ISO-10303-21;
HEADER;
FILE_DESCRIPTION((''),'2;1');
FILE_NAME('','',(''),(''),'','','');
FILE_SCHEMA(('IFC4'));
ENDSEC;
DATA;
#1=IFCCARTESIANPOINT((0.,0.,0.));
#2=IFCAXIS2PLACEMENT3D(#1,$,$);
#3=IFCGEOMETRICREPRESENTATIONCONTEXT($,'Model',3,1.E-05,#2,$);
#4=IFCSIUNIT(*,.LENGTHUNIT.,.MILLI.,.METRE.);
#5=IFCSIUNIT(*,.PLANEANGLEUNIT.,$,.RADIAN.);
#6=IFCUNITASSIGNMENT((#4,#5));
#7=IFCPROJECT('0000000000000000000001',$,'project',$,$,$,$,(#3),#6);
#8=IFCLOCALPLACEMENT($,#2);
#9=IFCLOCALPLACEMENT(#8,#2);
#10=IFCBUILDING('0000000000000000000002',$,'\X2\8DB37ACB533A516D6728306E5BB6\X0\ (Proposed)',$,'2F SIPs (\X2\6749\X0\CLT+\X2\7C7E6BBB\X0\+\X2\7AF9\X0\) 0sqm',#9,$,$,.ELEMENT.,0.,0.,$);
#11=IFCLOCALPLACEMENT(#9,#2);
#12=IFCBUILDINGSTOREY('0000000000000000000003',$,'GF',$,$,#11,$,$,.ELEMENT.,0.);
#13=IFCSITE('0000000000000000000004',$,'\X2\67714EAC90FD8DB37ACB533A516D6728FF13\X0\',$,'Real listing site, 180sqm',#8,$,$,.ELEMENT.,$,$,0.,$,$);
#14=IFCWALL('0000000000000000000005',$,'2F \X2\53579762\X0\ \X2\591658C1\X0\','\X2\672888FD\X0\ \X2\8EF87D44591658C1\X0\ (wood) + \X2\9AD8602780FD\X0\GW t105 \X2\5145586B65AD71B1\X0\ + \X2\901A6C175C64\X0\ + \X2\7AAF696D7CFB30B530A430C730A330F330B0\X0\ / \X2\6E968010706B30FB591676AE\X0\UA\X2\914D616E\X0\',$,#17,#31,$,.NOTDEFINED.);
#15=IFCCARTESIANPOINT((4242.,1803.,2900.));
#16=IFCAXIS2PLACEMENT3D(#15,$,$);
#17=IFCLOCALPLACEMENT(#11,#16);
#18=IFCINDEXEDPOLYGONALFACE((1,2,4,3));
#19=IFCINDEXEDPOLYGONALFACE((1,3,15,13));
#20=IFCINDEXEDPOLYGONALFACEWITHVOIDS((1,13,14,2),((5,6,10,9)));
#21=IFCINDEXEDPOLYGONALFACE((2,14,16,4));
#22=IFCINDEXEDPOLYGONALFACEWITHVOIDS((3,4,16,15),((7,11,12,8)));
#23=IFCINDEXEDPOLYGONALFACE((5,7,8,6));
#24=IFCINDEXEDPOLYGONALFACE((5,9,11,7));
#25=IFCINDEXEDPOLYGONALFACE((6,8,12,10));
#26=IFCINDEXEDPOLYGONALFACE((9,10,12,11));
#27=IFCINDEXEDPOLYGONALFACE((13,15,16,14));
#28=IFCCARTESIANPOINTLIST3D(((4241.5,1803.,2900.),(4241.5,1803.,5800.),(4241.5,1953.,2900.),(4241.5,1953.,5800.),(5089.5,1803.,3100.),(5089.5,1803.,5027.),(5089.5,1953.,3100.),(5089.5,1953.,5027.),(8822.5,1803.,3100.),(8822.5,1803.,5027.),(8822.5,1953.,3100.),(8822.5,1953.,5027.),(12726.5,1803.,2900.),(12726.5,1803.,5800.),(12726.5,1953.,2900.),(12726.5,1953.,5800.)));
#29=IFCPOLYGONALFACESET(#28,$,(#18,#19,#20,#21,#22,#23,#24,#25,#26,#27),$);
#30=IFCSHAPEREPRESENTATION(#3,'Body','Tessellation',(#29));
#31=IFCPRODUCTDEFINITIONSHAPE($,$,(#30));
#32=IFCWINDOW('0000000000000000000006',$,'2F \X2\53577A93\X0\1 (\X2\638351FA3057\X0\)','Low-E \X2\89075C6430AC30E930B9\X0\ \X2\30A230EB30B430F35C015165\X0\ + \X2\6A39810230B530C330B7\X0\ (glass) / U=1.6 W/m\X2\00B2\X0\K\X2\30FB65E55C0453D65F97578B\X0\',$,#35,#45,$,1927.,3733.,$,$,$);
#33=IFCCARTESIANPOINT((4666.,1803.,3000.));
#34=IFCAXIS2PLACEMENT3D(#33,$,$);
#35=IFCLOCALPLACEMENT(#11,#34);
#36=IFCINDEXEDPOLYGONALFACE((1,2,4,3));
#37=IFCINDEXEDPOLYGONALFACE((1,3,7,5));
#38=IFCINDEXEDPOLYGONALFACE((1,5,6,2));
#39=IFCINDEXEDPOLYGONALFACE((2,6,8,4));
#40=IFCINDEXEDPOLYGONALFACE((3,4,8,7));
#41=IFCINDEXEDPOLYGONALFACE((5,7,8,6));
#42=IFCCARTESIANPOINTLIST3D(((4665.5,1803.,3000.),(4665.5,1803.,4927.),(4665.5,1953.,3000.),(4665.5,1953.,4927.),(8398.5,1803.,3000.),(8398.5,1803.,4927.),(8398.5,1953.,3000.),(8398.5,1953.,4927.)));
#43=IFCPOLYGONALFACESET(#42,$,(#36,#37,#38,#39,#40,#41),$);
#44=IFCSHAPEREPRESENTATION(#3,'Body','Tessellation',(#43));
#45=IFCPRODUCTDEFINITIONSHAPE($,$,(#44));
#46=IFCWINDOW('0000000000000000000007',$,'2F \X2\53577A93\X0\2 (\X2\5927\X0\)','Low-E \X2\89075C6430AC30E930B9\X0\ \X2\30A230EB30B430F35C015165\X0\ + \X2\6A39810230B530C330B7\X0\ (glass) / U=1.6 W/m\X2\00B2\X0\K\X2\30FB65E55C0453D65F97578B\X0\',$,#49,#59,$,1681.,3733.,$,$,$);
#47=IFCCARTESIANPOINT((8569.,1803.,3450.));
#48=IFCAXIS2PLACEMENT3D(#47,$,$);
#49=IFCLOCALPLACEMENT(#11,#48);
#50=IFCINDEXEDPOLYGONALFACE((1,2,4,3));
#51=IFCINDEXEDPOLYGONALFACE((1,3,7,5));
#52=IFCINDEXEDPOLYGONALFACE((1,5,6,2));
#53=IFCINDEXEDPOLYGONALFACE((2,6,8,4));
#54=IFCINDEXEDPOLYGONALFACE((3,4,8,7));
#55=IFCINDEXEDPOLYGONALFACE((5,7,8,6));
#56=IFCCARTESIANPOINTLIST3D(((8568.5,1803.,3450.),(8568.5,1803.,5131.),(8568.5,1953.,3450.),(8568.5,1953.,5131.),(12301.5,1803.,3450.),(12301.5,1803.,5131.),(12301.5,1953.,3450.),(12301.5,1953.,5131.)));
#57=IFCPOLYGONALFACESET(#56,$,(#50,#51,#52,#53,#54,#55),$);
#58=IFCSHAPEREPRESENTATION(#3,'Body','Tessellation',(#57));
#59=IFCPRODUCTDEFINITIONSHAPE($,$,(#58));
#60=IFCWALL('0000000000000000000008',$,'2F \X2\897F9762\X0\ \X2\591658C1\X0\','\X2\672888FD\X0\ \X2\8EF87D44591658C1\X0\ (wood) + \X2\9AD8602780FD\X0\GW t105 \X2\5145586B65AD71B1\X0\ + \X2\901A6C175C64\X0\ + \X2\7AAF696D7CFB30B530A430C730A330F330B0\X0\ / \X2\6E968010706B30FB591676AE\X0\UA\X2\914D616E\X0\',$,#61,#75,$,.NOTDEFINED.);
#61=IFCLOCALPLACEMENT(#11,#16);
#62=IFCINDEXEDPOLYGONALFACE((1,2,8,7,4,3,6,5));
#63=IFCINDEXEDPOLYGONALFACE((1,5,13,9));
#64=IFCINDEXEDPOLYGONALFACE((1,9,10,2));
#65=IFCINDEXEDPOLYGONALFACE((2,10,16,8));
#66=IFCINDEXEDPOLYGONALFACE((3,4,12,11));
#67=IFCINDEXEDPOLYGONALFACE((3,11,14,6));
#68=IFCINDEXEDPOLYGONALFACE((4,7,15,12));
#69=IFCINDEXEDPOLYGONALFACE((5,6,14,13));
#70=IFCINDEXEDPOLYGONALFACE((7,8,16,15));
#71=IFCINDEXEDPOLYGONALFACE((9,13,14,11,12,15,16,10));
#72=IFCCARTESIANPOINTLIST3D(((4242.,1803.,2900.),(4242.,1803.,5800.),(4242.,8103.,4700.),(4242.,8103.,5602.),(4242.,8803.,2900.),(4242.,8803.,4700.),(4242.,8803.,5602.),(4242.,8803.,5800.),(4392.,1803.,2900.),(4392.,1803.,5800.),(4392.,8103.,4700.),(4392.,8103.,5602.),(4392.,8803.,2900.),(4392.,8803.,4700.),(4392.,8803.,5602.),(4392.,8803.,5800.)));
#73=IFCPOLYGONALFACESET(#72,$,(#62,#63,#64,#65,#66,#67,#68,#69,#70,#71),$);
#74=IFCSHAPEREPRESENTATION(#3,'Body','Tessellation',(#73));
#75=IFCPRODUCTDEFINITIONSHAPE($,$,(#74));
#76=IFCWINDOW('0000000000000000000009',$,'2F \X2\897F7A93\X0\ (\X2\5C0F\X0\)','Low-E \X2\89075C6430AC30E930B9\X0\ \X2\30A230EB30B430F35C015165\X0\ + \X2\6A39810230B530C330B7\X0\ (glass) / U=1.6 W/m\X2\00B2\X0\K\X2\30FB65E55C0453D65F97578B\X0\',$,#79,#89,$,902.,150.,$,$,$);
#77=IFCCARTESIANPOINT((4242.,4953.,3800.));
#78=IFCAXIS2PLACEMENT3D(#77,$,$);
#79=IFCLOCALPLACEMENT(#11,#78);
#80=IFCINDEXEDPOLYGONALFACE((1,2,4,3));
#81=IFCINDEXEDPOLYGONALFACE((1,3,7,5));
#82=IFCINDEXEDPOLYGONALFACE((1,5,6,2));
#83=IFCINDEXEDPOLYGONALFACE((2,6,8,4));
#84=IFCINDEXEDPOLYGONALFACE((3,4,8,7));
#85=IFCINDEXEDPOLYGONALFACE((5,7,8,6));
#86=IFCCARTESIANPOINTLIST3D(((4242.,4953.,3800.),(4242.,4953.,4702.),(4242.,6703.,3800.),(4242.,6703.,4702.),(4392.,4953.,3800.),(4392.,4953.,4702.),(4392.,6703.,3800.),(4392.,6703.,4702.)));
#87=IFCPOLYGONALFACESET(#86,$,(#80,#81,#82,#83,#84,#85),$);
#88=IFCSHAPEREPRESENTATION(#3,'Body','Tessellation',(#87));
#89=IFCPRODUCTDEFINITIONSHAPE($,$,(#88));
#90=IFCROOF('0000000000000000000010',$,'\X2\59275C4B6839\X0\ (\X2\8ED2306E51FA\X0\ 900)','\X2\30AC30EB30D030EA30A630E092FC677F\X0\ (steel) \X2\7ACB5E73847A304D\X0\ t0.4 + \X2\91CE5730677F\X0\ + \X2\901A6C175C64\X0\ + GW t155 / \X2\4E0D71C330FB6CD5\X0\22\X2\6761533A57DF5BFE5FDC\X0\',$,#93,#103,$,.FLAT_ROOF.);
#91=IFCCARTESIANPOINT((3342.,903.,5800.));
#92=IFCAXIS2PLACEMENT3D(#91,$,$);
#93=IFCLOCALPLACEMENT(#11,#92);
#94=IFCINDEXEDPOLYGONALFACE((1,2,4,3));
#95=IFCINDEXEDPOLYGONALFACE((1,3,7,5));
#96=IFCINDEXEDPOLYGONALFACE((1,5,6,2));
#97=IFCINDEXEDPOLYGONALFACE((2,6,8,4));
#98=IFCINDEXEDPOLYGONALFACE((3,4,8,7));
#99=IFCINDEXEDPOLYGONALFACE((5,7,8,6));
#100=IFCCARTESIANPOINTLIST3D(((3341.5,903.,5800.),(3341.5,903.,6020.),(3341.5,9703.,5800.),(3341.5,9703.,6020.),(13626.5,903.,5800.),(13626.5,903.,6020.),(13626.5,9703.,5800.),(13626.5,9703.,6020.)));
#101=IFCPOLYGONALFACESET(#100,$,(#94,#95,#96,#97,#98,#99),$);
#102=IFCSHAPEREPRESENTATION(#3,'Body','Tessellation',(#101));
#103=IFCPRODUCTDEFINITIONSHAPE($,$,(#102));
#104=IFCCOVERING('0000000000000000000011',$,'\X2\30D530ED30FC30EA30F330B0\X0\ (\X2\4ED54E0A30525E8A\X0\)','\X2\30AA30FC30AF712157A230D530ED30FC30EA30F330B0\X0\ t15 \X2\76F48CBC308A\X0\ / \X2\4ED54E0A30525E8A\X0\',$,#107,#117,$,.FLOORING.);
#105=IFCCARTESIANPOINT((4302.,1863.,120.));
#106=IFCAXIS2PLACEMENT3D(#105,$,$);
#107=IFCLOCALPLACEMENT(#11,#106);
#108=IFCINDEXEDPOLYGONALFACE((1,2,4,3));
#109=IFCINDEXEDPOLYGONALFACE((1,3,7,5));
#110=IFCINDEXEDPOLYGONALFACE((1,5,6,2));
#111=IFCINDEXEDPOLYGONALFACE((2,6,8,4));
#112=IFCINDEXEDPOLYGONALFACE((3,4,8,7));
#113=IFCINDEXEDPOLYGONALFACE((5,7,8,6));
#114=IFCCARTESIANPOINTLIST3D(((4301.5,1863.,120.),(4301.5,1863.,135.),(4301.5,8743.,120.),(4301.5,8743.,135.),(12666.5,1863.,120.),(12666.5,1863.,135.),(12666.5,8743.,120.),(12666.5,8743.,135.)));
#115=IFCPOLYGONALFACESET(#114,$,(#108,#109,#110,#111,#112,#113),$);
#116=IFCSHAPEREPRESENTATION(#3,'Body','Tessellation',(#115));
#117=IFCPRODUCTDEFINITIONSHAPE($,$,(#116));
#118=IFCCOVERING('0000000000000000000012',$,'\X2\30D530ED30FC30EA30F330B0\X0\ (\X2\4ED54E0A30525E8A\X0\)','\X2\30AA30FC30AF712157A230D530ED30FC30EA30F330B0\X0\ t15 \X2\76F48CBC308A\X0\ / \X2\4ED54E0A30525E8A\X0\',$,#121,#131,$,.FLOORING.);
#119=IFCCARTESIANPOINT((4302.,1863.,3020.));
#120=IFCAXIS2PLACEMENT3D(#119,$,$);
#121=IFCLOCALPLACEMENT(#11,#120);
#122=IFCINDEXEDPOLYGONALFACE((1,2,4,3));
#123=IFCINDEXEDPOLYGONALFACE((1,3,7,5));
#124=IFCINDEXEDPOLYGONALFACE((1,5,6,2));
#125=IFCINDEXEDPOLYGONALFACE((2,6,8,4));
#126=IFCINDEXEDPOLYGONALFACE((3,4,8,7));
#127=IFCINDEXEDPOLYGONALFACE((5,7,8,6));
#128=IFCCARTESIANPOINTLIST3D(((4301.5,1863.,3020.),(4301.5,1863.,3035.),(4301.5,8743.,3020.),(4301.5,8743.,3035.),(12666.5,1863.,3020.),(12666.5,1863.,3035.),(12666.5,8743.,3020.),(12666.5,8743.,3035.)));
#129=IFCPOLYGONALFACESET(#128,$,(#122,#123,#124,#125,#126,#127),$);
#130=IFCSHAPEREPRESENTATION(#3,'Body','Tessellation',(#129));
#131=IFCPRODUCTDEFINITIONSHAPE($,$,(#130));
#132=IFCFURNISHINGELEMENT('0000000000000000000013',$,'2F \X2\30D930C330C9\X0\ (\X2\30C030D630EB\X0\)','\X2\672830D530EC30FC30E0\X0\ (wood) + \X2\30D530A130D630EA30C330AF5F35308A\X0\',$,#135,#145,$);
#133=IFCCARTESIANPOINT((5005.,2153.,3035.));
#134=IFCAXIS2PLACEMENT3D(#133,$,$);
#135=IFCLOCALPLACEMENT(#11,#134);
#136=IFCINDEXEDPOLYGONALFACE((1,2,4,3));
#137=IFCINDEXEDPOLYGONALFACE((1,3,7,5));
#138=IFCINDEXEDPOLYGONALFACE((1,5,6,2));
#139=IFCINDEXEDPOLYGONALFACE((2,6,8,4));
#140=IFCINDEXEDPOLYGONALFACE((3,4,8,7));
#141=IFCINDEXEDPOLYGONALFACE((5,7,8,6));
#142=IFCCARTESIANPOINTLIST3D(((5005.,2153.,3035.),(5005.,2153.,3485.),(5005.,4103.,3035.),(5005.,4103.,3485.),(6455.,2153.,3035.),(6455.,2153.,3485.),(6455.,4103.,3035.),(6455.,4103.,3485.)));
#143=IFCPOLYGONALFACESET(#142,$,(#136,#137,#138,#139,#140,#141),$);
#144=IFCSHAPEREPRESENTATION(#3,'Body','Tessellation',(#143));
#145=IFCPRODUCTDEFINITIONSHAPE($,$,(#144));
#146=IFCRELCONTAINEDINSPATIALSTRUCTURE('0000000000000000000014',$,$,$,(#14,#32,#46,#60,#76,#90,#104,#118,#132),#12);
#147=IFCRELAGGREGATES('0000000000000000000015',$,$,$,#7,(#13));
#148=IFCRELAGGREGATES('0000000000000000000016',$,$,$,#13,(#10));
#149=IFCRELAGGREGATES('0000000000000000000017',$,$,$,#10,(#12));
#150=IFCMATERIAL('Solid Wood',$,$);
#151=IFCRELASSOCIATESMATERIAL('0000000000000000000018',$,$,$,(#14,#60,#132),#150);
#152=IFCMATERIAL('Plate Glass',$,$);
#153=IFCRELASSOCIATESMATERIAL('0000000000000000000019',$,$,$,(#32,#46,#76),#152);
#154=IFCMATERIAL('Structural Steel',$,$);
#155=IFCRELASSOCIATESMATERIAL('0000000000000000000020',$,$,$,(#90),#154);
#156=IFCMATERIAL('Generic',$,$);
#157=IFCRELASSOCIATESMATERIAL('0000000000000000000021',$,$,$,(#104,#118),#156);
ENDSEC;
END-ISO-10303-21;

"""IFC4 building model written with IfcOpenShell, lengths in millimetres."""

from ifc_helpers import new_model, si_unit, frame, frame_2d, origin, place, context, project, spatial, rectangle, extrude, material, element, fill, save


model = new_model("IFC4")

# Units and contexts
model_context = context("Model", 3, precision=1e-05, world=origin())
ifc_project = project(units=[si_unit("LENGTHUNIT", "METRE", prefix="MILLI"), si_unit("PLANEANGLEUNIT", "RADIAN")], contexts=[model_context])

# Site, building, storey
site_placement = place(None, origin())
site = spatial("IfcSite", under=ifc_project, at=site_placement, Name="東京都足立区六木３", ObjectType="Real listing site, 180sqm", CompositionType="ELEMENT", RefElevation=0.0)
building_placement = place(site_placement, origin())
building = spatial("IfcBuilding", under=site, at=building_placement, Name="足立区六木の家 (Proposed)", ObjectType="2F SIPs (杉CLT+籾殻+竹) 0sqm", CompositionType="ELEMENT", ElevationOfRefHeight=0.0, ElevationOfTerrain=0.0)
storey_placement = place(building_placement, origin())
storey = spatial("IfcBuildingStorey", under=building, at=storey_placement, Name="GF", CompositionType="ELEMENT", Elevation=0.0)

# Shared definitions
ifc_material_1 = material(Name="Solid Wood")

# Shared definitions
ifc_material_2 = material(Name="Plate Glass")

# Wall, openings, windows
wall_1_placement = place(storey_placement, frame((4242.0, 1803.0, 2900.0)))
wall_1 = element("IfcWall", 1, at=wall_1_placement, inside=storey, material=ifc_material_1, Name="2F 南面 外壁", Description="木製 軸組外壁 (wood) + 高性能GW t105 充填断熱 + 通気層 + 窯業系サイディング / 準耐火・外皮UA配慮", PredefinedType="NOTDEFINED", context=model_context, shape_type="SweptSolid", body=[
    extrude(rectangle(XDim=8485.0, YDim=150.0, at=frame_2d((4242.0, 75.0))), frame((4242.0, 1803.0, 2900.0)), (0.0, 0.0, 1.0), 2900.0),
])
opening_1_placement = place(storey_placement, frame((4666.0, 1803.0, 3000.0)))
opening_1 = element("IfcOpeningElement", 2, at=opening_1_placement, cuts=wall_1, PredefinedType="NOTDEFINED", context=model_context, shape_type="SweptSolid", body=[
    extrude(rectangle(XDim=3733.0, YDim=150.0, at=frame_2d((1866.0, 75.0))), frame((4666.0, 1803.0, 3000.0)), (0.0, 0.0, 1.0), 1927.0),
])
opening_2_placement = place(storey_placement, frame((8569.0, 1803.0, 3450.0)))
opening_2 = element("IfcOpeningElement", 3, at=opening_2_placement, cuts=wall_1, PredefinedType="NOTDEFINED", context=model_context, shape_type="SweptSolid", body=[
    extrude(rectangle(XDim=3733.0, YDim=150.0, at=frame_2d((1866.0, 75.0))), frame((8569.0, 1803.0, 3450.0)), (0.0, 0.0, 1.0), 1681.0),
])
window_1_placement = place(storey_placement, frame((4666.0, 1803.0, 3000.0)))
window_1 = element("IfcWindow", 4, at=window_1_placement, inside=storey, material=ifc_material_2, Name="2F 南窓1 (掃出し)", Description="Low-E 複層ガラス アルゴン封入 + 樹脂サッシ (glass) / U=1.6 W/m²K・日射取得型", OverallHeight=1927.0, OverallWidth=3733.0, context=model_context, shape_type="SweptSolid", body=[
    extrude(rectangle(XDim=3733.0, YDim=150.0, at=frame_2d((1866.0, 75.0))), frame((4666.0, 1803.0, 3000.0)), (0.0, 0.0, 1.0), 1927.0),
])
fill(opening_1, window_1)
window_2_placement = place(storey_placement, frame((8569.0, 1803.0, 3450.0)))
window_2 = element("IfcWindow", 5, at=window_2_placement, inside=storey, material=ifc_material_2, Name="2F 南窓2 (大)", Description="Low-E 複層ガラス アルゴン封入 + 樹脂サッシ (glass) / U=1.6 W/m²K・日射取得型", OverallHeight=1681.0, OverallWidth=3733.0, context=model_context, shape_type="SweptSolid", body=[
    extrude(rectangle(XDim=3733.0, YDim=150.0, at=frame_2d((1866.0, 75.0))), frame((8569.0, 1803.0, 3450.0)), (0.0, 0.0, 1.0), 1681.0),
])
fill(opening_2, window_2)

# Wall, opening, window
wall_2_placement = place(storey_placement, frame((4242.0, 1803.0, 2900.0)))
wall_2 = element("IfcWall", 6, at=wall_2_placement, inside=storey, material=ifc_material_1, Name="2F 西面 外壁", Description="木製 軸組外壁 (wood) + 高性能GW t105 充填断熱 + 通気層 + 窯業系サイディング / 準耐火・外皮UA配慮", PredefinedType="NOTDEFINED", context=model_context, shape_type="SweptSolid", body=[
    extrude(rectangle(XDim=150.0, YDim=7000.0, at=frame_2d((75.0, 3500.0))), frame((4242.0, 1803.0, 2900.0)), (0.0, 0.0, 1.0), 2900.0),
])
opening_3_placement = place(storey_placement, frame((4242.0, 4953.0, 3800.0)))
opening_3 = element("IfcOpeningElement", 7, at=opening_3_placement, cuts=wall_2, PredefinedType="NOTDEFINED", context=model_context, shape_type="SweptSolid", body=[
    extrude(rectangle(XDim=150.0, YDim=1750.0, at=frame_2d((75.0, 875.0))), frame((4242.0, 4953.0, 3800.0)), (0.0, 0.0, 1.0), 902.0),
])
window_3_placement = place(storey_placement, frame((4242.0, 4953.0, 3800.0)))
window_3 = element("IfcWindow", 8, at=window_3_placement, inside=storey, material=ifc_material_2, Name="2F 西窓 (小)", Description="Low-E 複層ガラス アルゴン封入 + 樹脂サッシ (glass) / U=1.6 W/m²K・日射取得型", OverallHeight=902.0, OverallWidth=150.0, context=model_context, shape_type="SweptSolid", body=[
    extrude(rectangle(XDim=150.0, YDim=1750.0, at=frame_2d((75.0, 875.0))), frame((4242.0, 4953.0, 3800.0)), (0.0, 0.0, 1.0), 902.0),
])
fill(opening_3, window_3)

# Roof
ifc_material_3 = material(Name="Structural Steel")
roof_placement = place(storey_placement, frame((3342.0, 903.0, 5800.0)))
element("IfcRoof", 9, at=roof_placement, inside=storey, material=ifc_material_3, Name="大屋根 (軒の出 900)", Description="ガルバリウム鋼板 (steel) 立平葺き t0.4 + 野地板 + 通気層 + GW t155 / 不燃・法22条区域対応", PredefinedType="FLAT_ROOF", context=model_context, shape_type="SweptSolid", body=[
    extrude(rectangle(XDim=10285.0, YDim=8800.0, at=frame_2d((5142.0, 4400.0))), frame((3342.0, 903.0, 5800.0)), (0.0, 0.0, 1.0), 220.0),
])

# Coverings
ifc_material_4 = material(Name="Generic")
covering_1_placement = place(storey_placement, frame((4302.0, 1863.0, 120.0)))
element("IfcCovering", 10, at=covering_1_placement, inside=storey, material=ifc_material_4, Name="フローリング (仕上げ床)", Description="オーク無垢フローリング t15 直貼り / 仕上げ床", PredefinedType="FLOORING", context=model_context, shape_type="SweptSolid", body=[
    extrude(rectangle(XDim=8365.0, YDim=6880.0, at=frame_2d((4182.0, 3440.0))), frame((4302.0, 1863.0, 120.0)), (0.0, 0.0, 1.0), 15.0),
])
covering_2_placement = place(storey_placement, frame((4302.0, 1863.0, 3020.0)))
element("IfcCovering", 11, at=covering_2_placement, inside=storey, material=ifc_material_4, Name="フローリング (仕上げ床)", Description="オーク無垢フローリング t15 直貼り / 仕上げ床", PredefinedType="FLOORING", context=model_context, shape_type="SweptSolid", body=[
    extrude(rectangle(XDim=8365.0, YDim=6880.0, at=frame_2d((4182.0, 3440.0))), frame((4302.0, 1863.0, 3020.0)), (0.0, 0.0, 1.0), 15.0),
])

# Furnishing element
furnishing_placement = place(storey_placement, frame((5005.0, 2153.0, 3035.0)))
element("IfcFurnishingElement", 12, at=furnishing_placement, inside=storey, material=ifc_material_1, Name="2F ベッド (ダブル)", Description="木フレーム (wood) + ファブリック張り", context=model_context, shape_type="SweptSolid", body=[
    extrude(rectangle(XDim=1450.0, YDim=1950.0, at=frame_2d((725.0, 975.0))), frame((5005.0, 2153.0, 3035.0)), (0.0, 0.0, 1.0), 450.0),
])

save(model, "model.ifc")
